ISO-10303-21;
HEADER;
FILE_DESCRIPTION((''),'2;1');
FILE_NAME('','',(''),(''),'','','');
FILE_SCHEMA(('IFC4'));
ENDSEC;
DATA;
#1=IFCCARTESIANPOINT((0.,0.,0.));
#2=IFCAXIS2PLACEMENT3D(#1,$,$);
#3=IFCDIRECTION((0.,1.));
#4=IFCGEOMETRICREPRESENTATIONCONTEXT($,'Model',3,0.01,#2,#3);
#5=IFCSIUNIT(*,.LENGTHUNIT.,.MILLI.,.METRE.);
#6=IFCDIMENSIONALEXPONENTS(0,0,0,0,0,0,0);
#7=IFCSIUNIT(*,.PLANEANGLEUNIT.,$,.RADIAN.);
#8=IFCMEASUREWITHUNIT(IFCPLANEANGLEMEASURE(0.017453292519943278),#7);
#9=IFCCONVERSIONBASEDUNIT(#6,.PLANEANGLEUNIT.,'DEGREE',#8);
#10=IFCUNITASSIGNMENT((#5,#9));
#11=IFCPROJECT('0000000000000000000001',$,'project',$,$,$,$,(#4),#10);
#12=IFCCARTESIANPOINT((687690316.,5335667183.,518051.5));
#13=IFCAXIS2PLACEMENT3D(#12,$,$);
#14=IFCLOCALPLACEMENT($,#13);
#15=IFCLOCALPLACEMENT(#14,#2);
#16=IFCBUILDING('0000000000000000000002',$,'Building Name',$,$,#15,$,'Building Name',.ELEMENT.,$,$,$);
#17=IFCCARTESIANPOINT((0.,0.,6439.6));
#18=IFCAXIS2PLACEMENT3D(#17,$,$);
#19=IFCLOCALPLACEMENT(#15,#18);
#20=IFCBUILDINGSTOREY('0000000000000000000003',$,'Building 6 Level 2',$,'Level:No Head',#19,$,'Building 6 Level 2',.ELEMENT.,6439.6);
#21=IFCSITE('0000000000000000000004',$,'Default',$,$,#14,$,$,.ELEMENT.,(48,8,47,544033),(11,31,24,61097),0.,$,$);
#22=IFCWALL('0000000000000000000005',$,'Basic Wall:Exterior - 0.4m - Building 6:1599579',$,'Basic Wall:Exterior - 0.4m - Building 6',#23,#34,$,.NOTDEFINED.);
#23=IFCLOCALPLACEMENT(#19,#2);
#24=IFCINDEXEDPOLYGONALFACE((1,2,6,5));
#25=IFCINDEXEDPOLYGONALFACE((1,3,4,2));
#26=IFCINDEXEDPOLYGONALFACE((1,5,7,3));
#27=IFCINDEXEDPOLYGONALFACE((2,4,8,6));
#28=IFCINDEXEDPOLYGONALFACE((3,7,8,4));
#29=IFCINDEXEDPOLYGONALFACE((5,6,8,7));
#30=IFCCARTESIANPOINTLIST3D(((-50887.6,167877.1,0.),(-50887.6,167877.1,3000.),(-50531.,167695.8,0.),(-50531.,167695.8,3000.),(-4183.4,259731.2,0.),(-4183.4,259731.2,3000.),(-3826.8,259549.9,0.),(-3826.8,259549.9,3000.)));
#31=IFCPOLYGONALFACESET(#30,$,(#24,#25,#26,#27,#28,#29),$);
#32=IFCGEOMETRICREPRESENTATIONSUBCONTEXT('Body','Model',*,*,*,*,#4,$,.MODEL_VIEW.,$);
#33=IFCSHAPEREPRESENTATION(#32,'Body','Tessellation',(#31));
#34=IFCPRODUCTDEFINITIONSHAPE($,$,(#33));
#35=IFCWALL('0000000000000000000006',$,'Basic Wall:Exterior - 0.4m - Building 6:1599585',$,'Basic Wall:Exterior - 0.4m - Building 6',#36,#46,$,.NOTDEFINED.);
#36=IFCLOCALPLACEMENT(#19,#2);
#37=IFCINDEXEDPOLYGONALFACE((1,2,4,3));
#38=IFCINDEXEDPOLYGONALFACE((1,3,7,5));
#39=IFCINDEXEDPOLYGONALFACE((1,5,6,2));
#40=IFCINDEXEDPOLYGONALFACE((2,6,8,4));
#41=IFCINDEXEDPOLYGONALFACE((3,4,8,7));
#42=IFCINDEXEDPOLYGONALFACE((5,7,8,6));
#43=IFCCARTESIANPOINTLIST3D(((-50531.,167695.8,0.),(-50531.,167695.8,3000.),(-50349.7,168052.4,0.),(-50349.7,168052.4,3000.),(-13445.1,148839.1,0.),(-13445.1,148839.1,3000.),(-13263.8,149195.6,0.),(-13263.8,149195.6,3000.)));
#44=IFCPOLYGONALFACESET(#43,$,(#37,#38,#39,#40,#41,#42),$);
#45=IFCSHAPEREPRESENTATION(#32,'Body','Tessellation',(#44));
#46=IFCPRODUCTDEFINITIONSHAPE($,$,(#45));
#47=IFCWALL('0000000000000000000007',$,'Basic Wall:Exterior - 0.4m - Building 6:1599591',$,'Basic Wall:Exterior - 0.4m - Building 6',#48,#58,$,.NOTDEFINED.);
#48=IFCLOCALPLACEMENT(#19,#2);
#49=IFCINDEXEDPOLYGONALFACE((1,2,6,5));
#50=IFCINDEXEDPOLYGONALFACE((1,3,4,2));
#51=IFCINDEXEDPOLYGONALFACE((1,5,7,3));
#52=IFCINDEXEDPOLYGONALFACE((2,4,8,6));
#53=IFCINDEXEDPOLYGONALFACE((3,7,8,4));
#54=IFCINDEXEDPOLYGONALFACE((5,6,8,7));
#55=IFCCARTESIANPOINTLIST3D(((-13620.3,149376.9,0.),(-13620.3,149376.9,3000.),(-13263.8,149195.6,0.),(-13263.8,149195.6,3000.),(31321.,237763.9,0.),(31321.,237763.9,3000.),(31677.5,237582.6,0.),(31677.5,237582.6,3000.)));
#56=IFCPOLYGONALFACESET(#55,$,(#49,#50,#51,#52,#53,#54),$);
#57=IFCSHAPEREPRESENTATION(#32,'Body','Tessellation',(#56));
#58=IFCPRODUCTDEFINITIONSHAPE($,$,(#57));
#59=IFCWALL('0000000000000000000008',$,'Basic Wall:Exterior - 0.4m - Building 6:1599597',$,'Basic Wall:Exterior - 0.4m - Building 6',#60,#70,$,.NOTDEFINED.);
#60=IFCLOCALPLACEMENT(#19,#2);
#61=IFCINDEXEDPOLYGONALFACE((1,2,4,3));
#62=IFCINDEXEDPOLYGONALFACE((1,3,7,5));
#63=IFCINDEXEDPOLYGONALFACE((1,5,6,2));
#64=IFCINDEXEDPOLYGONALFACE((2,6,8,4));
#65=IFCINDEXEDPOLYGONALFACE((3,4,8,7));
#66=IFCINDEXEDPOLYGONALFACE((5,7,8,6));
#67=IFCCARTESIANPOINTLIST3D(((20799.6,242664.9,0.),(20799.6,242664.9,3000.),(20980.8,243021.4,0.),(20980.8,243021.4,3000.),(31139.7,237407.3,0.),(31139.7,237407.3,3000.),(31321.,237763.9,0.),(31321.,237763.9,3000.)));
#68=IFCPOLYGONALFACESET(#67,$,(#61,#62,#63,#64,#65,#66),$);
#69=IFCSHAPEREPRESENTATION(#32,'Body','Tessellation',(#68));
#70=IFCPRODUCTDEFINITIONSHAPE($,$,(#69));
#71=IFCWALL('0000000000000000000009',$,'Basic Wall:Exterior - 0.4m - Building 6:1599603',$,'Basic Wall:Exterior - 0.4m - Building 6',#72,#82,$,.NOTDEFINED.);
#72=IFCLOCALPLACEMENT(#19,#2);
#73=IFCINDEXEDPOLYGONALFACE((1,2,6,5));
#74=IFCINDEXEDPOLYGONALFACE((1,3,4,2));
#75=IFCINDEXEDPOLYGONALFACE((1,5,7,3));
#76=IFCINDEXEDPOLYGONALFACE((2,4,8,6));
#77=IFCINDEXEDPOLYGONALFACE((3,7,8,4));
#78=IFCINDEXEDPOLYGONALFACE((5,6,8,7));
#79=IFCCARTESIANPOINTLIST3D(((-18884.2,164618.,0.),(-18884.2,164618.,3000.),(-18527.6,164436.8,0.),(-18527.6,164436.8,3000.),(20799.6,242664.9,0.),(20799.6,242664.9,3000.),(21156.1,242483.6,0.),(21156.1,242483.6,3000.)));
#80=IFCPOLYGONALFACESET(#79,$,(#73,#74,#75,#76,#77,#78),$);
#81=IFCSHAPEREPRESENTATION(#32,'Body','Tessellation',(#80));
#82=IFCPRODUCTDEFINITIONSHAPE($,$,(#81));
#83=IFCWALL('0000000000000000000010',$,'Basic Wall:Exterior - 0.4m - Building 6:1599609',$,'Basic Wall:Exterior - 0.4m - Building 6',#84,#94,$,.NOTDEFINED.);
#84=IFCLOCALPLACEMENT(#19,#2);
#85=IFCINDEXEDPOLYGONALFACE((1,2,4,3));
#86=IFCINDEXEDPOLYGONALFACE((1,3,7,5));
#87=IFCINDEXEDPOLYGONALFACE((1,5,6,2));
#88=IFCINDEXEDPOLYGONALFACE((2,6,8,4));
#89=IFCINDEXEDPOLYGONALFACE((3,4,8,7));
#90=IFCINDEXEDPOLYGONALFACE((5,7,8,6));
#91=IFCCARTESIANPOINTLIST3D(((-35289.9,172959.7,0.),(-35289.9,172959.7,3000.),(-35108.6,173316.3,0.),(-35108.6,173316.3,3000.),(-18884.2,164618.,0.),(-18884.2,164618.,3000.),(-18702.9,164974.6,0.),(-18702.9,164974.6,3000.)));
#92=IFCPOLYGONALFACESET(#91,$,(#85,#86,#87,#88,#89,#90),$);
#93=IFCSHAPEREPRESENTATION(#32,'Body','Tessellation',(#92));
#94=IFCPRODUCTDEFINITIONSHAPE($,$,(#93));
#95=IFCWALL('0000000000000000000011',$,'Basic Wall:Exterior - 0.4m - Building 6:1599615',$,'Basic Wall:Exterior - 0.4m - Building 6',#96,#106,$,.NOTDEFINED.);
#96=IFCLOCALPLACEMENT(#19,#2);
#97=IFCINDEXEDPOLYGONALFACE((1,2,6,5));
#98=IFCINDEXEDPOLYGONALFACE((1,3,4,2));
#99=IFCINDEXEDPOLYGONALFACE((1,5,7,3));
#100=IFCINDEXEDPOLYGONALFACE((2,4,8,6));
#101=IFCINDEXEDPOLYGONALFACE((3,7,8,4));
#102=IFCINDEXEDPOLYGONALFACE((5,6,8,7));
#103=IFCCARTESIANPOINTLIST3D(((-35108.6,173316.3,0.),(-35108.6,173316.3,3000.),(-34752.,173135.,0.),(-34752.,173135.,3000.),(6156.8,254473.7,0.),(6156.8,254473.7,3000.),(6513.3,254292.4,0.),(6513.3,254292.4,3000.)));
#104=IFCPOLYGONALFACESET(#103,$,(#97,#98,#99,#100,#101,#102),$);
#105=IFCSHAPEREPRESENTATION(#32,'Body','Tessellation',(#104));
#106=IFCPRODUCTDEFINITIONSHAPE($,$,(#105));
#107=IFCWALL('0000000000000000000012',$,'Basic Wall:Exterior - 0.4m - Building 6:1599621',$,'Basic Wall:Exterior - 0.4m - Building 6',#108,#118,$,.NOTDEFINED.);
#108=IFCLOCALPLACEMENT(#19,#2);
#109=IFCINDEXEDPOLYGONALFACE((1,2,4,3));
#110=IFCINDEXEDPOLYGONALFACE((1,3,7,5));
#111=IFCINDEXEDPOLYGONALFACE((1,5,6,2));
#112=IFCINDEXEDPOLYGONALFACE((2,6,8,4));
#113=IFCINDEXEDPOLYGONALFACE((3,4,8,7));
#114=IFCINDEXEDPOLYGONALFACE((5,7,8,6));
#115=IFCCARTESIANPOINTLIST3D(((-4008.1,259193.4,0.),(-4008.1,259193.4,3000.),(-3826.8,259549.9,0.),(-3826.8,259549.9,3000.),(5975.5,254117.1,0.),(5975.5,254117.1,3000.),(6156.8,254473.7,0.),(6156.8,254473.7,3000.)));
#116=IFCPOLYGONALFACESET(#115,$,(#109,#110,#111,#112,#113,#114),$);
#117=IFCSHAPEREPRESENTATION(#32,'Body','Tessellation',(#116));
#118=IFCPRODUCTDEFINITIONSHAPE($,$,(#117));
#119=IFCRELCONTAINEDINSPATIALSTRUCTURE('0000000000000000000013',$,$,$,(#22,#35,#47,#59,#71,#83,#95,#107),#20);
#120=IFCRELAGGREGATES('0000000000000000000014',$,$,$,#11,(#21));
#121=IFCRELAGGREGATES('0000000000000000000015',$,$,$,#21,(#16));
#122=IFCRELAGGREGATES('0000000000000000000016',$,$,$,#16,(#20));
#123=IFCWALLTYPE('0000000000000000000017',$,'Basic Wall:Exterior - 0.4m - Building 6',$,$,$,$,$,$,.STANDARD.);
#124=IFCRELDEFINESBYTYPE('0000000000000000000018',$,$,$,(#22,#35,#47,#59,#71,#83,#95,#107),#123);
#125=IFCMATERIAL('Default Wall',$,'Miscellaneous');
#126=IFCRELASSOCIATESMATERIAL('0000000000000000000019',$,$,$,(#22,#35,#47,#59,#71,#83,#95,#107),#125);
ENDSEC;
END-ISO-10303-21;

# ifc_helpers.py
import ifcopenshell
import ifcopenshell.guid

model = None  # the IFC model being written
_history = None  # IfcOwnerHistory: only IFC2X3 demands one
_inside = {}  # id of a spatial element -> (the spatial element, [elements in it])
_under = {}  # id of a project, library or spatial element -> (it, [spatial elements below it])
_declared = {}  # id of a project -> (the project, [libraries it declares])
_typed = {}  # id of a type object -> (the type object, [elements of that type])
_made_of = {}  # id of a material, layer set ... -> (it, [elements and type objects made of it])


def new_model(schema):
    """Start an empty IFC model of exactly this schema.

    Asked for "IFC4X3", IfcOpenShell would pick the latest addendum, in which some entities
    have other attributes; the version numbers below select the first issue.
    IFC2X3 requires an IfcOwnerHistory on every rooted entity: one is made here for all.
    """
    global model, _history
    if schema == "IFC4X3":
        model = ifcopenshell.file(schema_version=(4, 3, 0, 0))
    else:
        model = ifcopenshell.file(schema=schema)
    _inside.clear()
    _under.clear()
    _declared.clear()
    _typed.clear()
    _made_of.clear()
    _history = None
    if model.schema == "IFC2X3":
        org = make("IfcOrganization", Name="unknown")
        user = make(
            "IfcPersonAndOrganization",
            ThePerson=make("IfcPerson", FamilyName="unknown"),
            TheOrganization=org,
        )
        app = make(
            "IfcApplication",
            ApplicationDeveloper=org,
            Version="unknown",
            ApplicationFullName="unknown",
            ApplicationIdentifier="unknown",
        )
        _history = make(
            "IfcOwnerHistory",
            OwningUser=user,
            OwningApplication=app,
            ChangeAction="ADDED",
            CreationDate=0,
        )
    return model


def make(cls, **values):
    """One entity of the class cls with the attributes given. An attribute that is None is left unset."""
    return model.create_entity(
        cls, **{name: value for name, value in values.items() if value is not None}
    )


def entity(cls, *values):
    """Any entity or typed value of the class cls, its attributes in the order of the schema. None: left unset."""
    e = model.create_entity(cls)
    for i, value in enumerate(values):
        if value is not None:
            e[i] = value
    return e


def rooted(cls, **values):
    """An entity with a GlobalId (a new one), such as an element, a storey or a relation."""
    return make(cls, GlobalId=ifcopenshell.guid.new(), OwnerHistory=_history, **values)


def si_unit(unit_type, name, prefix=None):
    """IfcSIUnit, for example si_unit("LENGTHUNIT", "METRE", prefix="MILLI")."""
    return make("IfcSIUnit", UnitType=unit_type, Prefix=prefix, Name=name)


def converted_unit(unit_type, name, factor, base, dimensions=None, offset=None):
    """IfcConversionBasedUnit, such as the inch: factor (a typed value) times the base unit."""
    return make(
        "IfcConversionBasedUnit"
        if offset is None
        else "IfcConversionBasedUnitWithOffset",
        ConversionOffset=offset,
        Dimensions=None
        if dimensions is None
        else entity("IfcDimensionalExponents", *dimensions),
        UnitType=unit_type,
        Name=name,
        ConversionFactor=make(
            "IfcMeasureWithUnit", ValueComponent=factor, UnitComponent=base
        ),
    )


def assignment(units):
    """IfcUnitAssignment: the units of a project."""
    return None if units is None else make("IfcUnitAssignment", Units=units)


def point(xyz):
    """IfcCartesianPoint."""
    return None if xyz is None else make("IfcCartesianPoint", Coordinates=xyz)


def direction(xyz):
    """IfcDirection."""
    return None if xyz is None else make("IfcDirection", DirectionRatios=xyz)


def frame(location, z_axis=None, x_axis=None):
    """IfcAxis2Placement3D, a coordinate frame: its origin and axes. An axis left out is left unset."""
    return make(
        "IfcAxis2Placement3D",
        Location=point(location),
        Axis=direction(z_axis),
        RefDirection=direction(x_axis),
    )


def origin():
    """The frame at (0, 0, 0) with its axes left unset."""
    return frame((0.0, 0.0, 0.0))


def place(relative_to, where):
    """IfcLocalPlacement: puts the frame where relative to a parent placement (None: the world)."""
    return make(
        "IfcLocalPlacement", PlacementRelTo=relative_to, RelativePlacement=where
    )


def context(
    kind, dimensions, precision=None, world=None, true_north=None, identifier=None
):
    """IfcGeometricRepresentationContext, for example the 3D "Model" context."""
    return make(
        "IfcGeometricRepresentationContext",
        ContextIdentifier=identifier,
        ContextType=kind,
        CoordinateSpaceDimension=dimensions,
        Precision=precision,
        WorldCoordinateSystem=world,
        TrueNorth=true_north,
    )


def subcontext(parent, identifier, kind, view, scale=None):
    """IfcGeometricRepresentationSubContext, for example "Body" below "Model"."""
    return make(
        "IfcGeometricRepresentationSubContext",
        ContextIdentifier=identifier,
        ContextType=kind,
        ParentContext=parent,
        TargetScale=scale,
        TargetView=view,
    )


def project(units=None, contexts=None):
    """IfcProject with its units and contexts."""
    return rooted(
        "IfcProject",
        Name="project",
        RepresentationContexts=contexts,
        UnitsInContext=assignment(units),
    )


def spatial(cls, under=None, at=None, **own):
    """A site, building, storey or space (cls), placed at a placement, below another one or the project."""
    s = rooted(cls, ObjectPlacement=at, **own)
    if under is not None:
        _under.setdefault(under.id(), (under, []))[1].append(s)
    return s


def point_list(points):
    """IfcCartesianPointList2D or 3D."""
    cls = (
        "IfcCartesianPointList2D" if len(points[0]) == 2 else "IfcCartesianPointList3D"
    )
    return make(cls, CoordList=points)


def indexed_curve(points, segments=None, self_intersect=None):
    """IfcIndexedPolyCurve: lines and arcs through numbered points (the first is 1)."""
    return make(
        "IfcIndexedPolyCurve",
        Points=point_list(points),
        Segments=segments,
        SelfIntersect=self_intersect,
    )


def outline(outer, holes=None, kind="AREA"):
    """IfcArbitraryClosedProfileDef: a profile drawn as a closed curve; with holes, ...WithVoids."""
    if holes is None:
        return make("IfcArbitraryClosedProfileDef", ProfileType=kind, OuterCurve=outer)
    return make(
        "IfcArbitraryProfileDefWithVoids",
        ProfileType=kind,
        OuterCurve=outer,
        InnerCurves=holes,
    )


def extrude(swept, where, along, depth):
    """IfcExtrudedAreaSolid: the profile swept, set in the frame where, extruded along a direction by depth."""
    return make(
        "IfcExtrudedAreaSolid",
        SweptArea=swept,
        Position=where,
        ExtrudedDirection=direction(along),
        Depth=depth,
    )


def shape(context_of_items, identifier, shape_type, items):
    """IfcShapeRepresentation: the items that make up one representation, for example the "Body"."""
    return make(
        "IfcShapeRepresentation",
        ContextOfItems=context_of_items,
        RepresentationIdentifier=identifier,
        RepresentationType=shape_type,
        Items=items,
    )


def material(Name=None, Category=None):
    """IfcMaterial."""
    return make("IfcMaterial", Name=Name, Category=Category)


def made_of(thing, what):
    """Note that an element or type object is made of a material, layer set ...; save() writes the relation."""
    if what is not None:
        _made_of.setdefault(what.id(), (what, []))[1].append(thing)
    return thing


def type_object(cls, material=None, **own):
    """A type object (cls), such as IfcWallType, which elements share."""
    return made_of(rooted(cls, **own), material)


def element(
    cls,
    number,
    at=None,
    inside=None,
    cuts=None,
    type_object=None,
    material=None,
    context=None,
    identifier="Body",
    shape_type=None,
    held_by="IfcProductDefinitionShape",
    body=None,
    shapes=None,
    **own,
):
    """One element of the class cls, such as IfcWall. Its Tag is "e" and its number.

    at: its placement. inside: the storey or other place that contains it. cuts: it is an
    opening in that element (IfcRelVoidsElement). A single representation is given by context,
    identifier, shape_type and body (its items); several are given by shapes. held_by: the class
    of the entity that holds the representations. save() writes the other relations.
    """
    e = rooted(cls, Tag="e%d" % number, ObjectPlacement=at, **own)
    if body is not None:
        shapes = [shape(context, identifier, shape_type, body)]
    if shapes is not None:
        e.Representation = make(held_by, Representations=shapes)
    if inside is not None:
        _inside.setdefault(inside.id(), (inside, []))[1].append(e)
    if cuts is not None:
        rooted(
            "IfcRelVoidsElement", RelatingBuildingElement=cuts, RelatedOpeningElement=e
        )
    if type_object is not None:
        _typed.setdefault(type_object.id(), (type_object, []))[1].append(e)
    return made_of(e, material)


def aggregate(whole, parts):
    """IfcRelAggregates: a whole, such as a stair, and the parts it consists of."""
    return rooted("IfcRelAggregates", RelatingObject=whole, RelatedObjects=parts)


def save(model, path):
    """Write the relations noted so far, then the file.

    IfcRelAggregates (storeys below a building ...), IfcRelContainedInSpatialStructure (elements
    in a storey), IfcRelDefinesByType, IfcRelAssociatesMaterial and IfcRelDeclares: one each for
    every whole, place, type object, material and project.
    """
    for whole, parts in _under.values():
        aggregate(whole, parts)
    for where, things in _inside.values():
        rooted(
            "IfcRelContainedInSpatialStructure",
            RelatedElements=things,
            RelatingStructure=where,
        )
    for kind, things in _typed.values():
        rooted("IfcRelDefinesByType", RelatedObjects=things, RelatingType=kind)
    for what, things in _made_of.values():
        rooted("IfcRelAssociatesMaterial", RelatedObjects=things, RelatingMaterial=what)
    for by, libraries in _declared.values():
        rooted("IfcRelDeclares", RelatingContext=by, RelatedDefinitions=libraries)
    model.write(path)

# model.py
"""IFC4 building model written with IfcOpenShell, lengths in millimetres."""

from ifc_helpers import new_model, entity, si_unit, converted_unit, direction, frame, origin, place, context, subcontext, project, spatial, indexed_curve, outline, extrude, material, type_object, element, save


model = new_model("IFC4")

# Units and contexts
model_context = context("Model", 3, precision=0.01, world=origin(), true_north=direction((0.0, 1.0)))
body_context = subcontext(model_context, "Body", "Model", "MODEL_VIEW")
ifc_project = project(units=[si_unit("LENGTHUNIT", "METRE", prefix="MILLI"), converted_unit("PLANEANGLEUNIT", "DEGREE", entity("IfcPlaneAngleMeasure", 0.017453292519943278), si_unit("PLANEANGLEUNIT", "RADIAN"), dimensions=[0, 0, 0, 0, 0, 0, 0])], contexts=[model_context])

# Site, building, storey
site_placement = place(None, frame((687690316.0, 5335667183.0, 518051.5)))
site = spatial("IfcSite", under=ifc_project, at=site_placement, Name="Default", CompositionType="ELEMENT", RefLatitude=(48, 8, 47, 544033), RefLongitude=(11, 31, 24, 61097), RefElevation=0.0)
building_placement = place(site_placement, origin())
building = spatial("IfcBuilding", under=site, at=building_placement, Name="Building Name", LongName="Building Name", CompositionType="ELEMENT")
storey_placement = place(building_placement, frame((0.0, 0.0, 6439.6)))
storey = spatial("IfcBuildingStorey", under=building, at=storey_placement, Name="Building 6 Level 2", ObjectType="Level:No Head", LongName="Building 6 Level 2", CompositionType="ELEMENT", Elevation=6439.6)

# Walls
ifc_material_1 = material(Name="Default Wall", Category="Miscellaneous")
wall_type = type_object("IfcWallType", Name="Basic Wall:Exterior - 0.4m - Building 6", PredefinedType="STANDARD")
wall_1_placement = place(storey_placement, frame((-4005.1, 259640.6, 0.0), z_axis=(0.0, 0.0, 1.0), x_axis=(-0.453237, -0.89139, 0.0)))
element("IfcWall", 1, at=wall_1_placement, inside=storey, type_object=wall_type, material=ifc_material_1, Name="Basic Wall:Exterior - 0.4m - Building 6:1599579", ObjectType="Basic Wall:Exterior - 0.4m - Building 6", PredefinedType="NOTDEFINED", context=body_context, shape_type="SweptSolid", body=[
    extrude(outline(indexed_curve([(103045.9, 200.0), (0.0, 200.0), (0.0, -200.0), (103045.9, -200.0), (103045.9, 200.0)], self_intersect=False)), origin(), (0.0, 0.0, 1.0), 3000.0),
])
wall_2_placement = place(storey_placement, frame((-50440.4, 167874.1, 0.0), z_axis=(0.0, 0.0, 1.0), x_axis=(0.89139, -0.453237, 0.0)))
element("IfcWall", 2, at=wall_2_placement, inside=storey, type_object=wall_type, material=ifc_material_1, Name="Basic Wall:Exterior - 0.4m - Building 6:1599585", ObjectType="Basic Wall:Exterior - 0.4m - Building 6", PredefinedType="NOTDEFINED", context=body_context, shape_type="SweptSolid", body=[
    extrude(outline(indexed_curve([(41604.6, 200.0), (0.0, 200.0), (0.0, -200.0), (41604.6, -200.0), (41604.6, 200.0)], self_intersect=False)), origin(), (0.0, 0.0, 1.0), 3000.0),
])
wall_3_placement = place(storey_placement, frame((-13442.0, 149286.3, 0.0), z_axis=(0.0, 0.0, 1.0), x_axis=(0.453237, 0.89139, 0.0)))
element("IfcWall", 3, at=wall_3_placement, inside=storey, type_object=wall_type, material=ifc_material_1, Name="Basic Wall:Exterior - 0.4m - Building 6:1599591", ObjectType="Basic Wall:Exterior - 0.4m - Building 6", PredefinedType="NOTDEFINED", context=body_context, shape_type="SweptSolid", body=[
    extrude(outline(indexed_curve([(99156.3, 200.0), (0.0, 200.0), (0.0, -200.0), (99156.3, -200.0), (99156.3, 200.0)], self_intersect=False)), origin(), (0.0, 0.0, 1.0), 3000.0),
])
wall_4_placement = place(storey_placement, frame((31230.3, 237585.6, 0.0), z_axis=(0.0, 0.0, 1.0), x_axis=(-0.89139, 0.453237, 0.0)))
element("IfcWall", 4, at=wall_4_placement, inside=storey, type_object=wall_type, material=ifc_material_1, Name="Basic Wall:Exterior - 0.4m - Building 6:1599597", ObjectType="Basic Wall:Exterior - 0.4m - Building 6", PredefinedType="NOTDEFINED", context=body_context, shape_type="SweptSolid", body=[
    extrude(outline(indexed_curve([(11600.0, 200.0), (0.0, 200.0), (0.0, -200.0), (11600.0, -200.0), (11600.0, 200.0)], self_intersect=False)), origin(), (0.0, 0.0, 1.0), 3000.0),
])
wall_5_placement = place(storey_placement, frame((20977.8, 242574.2, 0.0), z_axis=(0.0, 0.0, 1.0), x_axis=(-0.453237, -0.89139, 0.0)))
element("IfcWall", 5, at=wall_5_placement, inside=storey, type_object=wall_type, material=ifc_material_1, Name="Basic Wall:Exterior - 0.4m - Building 6:1599603", ObjectType="Basic Wall:Exterior - 0.4m - Building 6", PredefinedType="NOTDEFINED", context=body_context, shape_type="SweptSolid", body=[
    extrude(outline(indexed_curve([(87556.3, 200.0), (0.0, 200.0), (0.0, -200.0), (87556.3, -200.0), (87556.3, 200.0)], self_intersect=False)), origin(), (0.0, 0.0, 1.0), 3000.0),
])
wall_6_placement = place(storey_placement, frame((-18793.5, 164796.3, 0.0), z_axis=(0.0, 0.0, 1.0), x_axis=(-0.89139, 0.453237, 0.0)))
element("IfcWall", 6, at=wall_6_placement, inside=storey, type_object=wall_type, material=ifc_material_1, Name="Basic Wall:Exterior - 0.4m - Building 6:1599609", ObjectType="Basic Wall:Exterior - 0.4m - Building 6", PredefinedType="NOTDEFINED", context=body_context, shape_type="SweptSolid", body=[
    extrude(outline(indexed_curve([(18404.6, 200.0), (0.0, 200.0), (0.0, -200.0), (18404.6, -200.0), (18404.6, 200.0)], self_intersect=False)), origin(), (0.0, 0.0, 1.0), 3000.0),
])
wall_7_placement = place(storey_placement, frame((-34930.3, 173225.6, 0.0), z_axis=(0.0, 0.0, 1.0), x_axis=(0.453237, 0.89139, 0.0)))
element("IfcWall", 7, at=wall_7_placement, inside=storey, type_object=wall_type, material=ifc_material_1, Name="Basic Wall:Exterior - 0.4m - Building 6:1599615", ObjectType="Basic Wall:Exterior - 0.4m - Building 6", PredefinedType="NOTDEFINED", context=body_context, shape_type="SweptSolid", body=[
    extrude(outline(indexed_curve([(91045.9, 200.0), (0.0, 200.0), (0.0, -200.0), (91045.9, -200.0), (91045.9, 200.0)], self_intersect=False)), origin(), (0.0, 0.0, 1.0), 3000.0),
])
wall_8_placement = place(storey_placement, frame((6066.1, 254295.4, 0.0), z_axis=(0.0, 0.0, 1.0), x_axis=(-0.89139, 0.453237, 0.0)))
element("IfcWall", 8, at=wall_8_placement, inside=storey, type_object=wall_type, material=ifc_material_1, Name="Basic Wall:Exterior - 0.4m - Building 6:1599621", ObjectType="Basic Wall:Exterior - 0.4m - Building 6", PredefinedType="NOTDEFINED", context=body_context, shape_type="SweptSolid", body=[
    extrude(outline(indexed_curve([(11200.0, 200.0), (0.0, 200.0), (0.0, -200.0), (11200.0, -200.0), (11200.0, 200.0)], self_intersect=False)), origin(), (0.0, 0.0, 1.0), 3000.0),
])

save(model, "model.ifc")
